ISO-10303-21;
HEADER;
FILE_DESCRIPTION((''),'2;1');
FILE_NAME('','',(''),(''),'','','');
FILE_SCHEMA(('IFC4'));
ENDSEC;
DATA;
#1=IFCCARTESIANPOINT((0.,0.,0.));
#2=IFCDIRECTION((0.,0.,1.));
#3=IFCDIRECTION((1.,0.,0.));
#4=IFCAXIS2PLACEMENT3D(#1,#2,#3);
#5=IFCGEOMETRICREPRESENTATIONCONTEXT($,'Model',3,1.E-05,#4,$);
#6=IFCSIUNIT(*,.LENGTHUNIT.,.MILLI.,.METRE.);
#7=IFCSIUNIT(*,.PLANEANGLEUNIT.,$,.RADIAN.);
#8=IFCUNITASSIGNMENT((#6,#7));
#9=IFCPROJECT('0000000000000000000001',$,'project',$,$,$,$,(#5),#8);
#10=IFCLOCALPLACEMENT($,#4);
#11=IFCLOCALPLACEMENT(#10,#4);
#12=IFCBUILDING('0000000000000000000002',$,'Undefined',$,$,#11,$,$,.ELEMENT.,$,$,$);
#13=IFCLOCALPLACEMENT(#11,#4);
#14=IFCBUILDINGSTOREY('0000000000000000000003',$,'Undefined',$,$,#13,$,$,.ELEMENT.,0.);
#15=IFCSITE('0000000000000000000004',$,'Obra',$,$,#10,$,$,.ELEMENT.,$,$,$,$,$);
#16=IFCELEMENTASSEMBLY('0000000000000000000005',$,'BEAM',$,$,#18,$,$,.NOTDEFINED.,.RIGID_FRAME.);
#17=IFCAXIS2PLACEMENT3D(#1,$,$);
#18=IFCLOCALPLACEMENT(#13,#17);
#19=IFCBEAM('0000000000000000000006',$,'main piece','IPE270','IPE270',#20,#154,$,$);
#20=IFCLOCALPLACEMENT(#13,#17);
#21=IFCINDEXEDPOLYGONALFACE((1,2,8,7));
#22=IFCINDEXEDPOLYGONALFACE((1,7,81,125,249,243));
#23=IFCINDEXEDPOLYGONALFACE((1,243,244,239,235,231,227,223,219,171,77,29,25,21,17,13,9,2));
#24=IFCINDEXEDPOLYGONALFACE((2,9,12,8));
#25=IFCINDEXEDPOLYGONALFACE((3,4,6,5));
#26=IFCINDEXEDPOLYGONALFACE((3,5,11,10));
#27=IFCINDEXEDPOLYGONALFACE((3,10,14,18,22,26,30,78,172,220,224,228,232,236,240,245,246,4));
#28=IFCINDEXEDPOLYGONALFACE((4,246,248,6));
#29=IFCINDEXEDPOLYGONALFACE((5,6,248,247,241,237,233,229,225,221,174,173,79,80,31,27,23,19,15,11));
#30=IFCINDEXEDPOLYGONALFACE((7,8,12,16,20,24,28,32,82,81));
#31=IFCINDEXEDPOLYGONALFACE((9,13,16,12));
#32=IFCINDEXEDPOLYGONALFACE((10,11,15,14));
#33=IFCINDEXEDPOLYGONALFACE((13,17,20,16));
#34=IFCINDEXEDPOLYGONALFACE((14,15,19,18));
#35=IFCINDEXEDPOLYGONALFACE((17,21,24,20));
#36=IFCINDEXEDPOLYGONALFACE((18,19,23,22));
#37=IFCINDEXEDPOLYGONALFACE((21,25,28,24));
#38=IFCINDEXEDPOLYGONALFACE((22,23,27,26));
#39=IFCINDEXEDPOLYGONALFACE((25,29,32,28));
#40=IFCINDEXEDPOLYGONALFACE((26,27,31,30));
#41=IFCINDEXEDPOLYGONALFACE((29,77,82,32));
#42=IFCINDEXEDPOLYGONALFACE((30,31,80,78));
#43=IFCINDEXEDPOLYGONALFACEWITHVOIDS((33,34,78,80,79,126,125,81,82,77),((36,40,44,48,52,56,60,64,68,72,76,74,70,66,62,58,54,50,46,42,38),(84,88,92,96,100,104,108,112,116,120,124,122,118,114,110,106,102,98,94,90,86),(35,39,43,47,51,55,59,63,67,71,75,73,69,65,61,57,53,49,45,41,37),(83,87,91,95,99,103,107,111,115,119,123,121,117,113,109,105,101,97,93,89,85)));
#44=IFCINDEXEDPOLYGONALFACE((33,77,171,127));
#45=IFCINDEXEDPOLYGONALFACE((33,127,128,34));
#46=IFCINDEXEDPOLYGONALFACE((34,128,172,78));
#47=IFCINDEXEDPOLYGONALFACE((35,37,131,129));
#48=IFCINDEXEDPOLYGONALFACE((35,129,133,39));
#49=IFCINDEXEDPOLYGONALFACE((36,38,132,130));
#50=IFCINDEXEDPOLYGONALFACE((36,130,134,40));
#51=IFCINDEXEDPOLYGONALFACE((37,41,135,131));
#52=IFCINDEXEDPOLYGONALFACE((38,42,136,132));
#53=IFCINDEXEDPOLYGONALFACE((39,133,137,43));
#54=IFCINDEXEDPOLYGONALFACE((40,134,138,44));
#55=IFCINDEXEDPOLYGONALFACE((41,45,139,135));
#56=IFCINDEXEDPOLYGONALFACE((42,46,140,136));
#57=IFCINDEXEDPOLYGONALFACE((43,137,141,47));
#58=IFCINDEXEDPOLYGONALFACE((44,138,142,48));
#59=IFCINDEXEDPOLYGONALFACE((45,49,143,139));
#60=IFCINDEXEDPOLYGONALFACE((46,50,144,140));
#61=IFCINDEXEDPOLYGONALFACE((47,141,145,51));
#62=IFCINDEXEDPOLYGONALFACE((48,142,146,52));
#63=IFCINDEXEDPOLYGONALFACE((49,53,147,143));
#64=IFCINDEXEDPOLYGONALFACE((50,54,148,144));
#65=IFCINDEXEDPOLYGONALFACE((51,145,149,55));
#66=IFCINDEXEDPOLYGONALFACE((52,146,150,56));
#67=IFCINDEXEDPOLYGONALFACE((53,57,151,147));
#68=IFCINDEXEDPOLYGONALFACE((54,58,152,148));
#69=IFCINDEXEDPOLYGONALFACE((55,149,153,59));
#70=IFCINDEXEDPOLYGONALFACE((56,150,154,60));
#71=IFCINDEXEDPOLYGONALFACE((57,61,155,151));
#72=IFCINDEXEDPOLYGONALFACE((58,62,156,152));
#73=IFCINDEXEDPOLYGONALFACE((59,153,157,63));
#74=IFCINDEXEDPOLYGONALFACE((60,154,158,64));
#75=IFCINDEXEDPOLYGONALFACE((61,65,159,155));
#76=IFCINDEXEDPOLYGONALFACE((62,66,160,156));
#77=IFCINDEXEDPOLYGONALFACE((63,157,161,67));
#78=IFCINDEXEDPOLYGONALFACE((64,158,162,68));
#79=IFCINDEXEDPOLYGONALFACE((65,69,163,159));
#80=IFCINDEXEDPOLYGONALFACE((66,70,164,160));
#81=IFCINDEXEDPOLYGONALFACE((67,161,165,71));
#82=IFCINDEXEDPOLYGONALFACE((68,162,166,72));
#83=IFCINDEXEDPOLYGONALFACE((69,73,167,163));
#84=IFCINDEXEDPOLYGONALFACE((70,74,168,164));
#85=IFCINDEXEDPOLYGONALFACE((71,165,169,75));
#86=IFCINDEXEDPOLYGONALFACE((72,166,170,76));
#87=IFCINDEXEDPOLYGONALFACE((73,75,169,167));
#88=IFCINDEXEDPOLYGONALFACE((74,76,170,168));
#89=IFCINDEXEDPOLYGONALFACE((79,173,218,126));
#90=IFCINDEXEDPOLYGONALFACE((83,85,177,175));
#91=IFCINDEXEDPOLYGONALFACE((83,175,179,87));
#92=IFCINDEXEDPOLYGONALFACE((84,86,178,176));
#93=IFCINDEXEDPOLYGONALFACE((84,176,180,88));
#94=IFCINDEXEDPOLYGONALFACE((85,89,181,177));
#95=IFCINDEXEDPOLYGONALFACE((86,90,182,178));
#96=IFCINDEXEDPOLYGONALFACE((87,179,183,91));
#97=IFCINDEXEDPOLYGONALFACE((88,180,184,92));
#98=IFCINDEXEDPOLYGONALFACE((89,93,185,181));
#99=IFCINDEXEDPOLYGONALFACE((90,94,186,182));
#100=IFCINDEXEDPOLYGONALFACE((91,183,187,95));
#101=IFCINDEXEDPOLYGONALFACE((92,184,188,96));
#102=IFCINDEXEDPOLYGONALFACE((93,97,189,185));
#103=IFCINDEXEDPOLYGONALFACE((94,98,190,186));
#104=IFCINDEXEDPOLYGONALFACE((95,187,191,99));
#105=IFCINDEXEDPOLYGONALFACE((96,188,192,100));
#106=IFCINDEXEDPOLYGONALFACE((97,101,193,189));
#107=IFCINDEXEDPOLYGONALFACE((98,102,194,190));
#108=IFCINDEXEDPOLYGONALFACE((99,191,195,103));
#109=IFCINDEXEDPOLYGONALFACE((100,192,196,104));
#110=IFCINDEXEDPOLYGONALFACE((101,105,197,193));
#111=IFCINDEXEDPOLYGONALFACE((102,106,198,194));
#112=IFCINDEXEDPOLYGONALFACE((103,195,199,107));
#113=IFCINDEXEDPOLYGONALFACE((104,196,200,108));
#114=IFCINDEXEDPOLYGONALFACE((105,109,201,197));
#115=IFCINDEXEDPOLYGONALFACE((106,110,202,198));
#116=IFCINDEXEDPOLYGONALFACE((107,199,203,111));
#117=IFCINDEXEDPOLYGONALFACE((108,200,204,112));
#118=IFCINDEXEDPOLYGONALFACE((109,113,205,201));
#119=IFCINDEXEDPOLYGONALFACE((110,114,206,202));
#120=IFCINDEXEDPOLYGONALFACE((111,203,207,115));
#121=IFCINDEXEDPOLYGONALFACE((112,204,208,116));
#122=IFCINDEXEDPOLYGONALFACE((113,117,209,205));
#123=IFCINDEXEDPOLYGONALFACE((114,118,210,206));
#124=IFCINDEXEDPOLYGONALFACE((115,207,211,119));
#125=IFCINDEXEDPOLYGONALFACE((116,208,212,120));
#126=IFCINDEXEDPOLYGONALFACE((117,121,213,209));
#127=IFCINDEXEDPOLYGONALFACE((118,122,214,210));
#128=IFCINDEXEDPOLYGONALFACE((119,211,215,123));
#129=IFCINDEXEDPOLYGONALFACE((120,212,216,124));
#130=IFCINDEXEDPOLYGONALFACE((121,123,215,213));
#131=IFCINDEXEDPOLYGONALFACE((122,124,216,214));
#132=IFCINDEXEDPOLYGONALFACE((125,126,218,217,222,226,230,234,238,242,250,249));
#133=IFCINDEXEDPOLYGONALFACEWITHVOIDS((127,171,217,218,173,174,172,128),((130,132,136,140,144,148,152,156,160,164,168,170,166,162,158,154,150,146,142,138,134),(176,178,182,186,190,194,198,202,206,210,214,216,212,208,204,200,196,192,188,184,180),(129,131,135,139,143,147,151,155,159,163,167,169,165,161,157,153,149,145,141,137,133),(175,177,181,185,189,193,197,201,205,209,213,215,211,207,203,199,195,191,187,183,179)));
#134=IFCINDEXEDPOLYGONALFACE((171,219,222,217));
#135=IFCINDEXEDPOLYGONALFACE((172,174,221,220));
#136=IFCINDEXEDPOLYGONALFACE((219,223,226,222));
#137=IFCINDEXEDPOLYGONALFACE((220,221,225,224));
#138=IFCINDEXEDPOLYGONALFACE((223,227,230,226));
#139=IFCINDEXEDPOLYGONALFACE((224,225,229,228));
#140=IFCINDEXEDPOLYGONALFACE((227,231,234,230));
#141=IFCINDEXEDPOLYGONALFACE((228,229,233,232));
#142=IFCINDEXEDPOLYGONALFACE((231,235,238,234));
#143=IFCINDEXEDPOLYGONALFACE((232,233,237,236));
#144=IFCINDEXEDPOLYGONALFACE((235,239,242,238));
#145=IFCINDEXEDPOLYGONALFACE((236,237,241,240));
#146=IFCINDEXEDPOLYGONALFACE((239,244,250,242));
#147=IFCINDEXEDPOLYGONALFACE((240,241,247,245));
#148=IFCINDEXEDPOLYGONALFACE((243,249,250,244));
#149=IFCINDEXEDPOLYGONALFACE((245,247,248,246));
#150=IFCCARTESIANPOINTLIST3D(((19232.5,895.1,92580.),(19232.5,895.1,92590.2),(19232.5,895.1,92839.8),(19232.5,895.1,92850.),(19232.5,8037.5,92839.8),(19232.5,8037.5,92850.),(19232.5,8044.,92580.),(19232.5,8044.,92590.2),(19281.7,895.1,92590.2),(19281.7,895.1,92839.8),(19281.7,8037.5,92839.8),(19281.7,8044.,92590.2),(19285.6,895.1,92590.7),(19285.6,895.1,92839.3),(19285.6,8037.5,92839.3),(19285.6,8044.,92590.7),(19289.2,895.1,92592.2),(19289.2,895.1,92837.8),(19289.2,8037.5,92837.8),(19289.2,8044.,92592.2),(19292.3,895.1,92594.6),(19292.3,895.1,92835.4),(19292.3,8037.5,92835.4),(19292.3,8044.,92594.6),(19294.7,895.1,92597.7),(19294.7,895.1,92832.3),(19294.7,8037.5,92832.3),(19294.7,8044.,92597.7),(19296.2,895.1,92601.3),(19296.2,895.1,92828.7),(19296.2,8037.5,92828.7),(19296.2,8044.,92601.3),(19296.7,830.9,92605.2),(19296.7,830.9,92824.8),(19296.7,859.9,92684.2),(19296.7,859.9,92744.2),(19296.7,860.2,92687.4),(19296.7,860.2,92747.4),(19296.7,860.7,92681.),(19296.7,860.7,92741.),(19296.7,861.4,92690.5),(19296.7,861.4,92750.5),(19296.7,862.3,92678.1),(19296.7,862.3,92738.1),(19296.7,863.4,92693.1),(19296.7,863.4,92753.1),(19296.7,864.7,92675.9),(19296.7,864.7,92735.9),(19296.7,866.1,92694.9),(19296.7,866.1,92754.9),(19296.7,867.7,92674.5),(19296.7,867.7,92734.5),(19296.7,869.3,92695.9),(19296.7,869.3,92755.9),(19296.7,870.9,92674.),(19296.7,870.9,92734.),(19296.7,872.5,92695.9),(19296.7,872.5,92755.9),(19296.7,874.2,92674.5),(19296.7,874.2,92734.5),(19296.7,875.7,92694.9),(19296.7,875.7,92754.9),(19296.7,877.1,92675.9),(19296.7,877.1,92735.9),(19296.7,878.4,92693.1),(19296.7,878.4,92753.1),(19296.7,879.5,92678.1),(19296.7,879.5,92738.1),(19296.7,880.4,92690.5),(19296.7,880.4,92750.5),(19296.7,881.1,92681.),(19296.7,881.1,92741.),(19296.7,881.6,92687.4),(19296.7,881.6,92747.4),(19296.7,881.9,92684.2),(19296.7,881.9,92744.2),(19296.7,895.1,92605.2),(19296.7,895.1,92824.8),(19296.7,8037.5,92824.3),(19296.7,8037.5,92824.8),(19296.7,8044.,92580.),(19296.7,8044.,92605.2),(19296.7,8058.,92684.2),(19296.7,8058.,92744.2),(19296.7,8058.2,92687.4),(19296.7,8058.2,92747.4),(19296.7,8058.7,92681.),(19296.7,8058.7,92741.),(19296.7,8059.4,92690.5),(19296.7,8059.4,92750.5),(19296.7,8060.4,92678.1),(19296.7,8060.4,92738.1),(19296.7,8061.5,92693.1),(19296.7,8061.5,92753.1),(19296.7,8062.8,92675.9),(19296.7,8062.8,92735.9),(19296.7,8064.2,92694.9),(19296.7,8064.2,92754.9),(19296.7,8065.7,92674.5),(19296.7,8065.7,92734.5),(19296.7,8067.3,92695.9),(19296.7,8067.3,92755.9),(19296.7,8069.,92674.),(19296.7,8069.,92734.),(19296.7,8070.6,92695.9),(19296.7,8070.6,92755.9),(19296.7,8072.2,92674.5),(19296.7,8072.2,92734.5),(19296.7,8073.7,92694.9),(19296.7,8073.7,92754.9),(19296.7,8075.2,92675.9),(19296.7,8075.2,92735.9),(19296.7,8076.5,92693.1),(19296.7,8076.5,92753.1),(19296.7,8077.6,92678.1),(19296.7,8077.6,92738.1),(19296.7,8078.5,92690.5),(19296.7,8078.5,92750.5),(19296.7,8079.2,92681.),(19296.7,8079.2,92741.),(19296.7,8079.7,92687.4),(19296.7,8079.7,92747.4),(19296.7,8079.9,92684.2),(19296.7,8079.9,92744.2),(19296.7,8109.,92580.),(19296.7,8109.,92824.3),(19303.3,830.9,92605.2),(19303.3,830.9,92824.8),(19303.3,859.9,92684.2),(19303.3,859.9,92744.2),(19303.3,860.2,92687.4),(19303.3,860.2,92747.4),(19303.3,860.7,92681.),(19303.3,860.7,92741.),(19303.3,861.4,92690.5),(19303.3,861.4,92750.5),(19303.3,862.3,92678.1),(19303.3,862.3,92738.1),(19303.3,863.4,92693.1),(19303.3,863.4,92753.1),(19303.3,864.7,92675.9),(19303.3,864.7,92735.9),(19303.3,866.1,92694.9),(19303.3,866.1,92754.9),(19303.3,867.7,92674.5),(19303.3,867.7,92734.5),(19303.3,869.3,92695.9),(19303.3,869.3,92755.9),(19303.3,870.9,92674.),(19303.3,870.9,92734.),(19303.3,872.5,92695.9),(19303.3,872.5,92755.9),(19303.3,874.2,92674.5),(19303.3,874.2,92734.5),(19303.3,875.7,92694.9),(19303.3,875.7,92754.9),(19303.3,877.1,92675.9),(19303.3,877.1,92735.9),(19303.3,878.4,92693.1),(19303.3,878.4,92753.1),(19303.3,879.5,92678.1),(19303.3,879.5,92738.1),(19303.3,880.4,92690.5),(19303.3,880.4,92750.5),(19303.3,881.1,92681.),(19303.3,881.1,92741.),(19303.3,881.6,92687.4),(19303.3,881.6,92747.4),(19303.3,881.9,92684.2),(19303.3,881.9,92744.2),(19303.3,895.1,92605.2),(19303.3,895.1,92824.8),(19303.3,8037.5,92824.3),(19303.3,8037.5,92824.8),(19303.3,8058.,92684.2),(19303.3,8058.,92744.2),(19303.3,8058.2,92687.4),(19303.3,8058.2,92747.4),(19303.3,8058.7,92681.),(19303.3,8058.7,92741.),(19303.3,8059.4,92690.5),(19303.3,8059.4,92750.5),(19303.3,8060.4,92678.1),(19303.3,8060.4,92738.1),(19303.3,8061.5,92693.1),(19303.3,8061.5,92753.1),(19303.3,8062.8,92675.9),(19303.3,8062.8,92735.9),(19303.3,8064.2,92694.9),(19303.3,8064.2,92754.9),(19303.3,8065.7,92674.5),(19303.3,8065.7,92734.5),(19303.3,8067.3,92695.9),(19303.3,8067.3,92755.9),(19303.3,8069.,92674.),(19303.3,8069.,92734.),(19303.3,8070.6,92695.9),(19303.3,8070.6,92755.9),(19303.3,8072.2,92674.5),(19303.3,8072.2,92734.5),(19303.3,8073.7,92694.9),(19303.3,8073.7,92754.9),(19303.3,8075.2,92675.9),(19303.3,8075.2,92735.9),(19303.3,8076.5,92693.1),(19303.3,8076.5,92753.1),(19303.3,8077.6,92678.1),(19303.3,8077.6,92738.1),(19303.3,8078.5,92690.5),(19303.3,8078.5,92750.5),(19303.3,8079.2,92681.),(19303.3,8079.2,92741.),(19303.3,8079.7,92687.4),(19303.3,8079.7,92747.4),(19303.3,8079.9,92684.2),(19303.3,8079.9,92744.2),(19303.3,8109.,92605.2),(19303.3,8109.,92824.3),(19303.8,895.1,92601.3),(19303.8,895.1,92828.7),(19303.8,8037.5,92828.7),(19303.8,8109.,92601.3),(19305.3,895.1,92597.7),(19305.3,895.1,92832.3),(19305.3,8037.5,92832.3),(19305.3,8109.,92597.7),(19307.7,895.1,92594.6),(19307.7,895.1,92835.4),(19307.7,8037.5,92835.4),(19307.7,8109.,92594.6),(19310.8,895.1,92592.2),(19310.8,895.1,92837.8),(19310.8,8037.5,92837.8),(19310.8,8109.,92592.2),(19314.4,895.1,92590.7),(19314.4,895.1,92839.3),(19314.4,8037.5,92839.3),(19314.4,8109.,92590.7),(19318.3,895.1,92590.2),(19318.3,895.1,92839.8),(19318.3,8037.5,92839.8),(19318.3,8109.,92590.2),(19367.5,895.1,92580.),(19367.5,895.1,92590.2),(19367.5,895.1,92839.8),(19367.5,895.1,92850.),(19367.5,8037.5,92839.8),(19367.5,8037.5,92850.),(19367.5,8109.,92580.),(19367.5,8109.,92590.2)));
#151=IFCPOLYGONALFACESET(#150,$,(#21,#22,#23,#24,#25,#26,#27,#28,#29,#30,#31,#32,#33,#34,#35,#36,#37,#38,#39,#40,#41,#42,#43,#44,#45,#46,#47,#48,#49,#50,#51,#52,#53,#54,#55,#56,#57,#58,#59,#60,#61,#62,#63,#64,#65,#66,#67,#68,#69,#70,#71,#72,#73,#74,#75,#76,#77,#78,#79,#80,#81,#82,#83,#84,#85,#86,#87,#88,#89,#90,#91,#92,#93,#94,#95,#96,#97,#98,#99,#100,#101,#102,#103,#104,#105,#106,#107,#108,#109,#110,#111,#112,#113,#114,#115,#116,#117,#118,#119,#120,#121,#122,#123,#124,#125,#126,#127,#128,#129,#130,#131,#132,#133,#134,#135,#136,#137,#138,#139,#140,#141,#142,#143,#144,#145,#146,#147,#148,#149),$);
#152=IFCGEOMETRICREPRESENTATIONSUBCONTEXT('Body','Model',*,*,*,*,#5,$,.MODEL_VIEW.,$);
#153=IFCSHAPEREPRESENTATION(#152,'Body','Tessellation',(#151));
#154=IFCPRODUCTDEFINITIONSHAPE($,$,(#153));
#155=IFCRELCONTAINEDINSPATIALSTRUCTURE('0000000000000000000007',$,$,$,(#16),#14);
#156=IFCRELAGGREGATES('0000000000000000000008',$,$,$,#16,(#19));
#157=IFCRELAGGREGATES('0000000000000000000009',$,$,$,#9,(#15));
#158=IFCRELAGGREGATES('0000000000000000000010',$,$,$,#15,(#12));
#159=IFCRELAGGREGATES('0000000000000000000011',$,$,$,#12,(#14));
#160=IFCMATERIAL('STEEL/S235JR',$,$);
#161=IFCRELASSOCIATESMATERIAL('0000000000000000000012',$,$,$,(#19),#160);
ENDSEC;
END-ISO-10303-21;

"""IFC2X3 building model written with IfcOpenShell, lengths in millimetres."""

from ifc_helpers import new_model, si_unit, frame, origin_with_axes, origin_2d_with_axis, place, context, subcontext, project, spatial, rectangle, circle, i_section, extrude, clip, halfspace, source, transform, mapped, material, element, aggregate, save


model = new_model("IFC2X3")

# Units and contexts
model_context = context("Model", 3, precision=1e-05, world=origin_with_axes())
body_context = subcontext(model_context, "Body", "Model", "MODEL_VIEW")
ifc_project = project(units=[si_unit("LENGTHUNIT", "METRE", prefix="MILLI"), si_unit("PLANEANGLEUNIT", "RADIAN")], contexts=[model_context])

# Site, building, storey
site_placement = place(None, origin_with_axes())
site = spatial("IfcSite", under=ifc_project, at=site_placement, Name="Obra", CompositionType="ELEMENT")
building_placement = place(site_placement, origin_with_axes())
building = spatial("IfcBuilding", under=site, at=building_placement, Name="Undefined", CompositionType="ELEMENT")
storey_placement = place(building_placement, origin_with_axes())
storey = spatial("IfcBuildingStorey", under=building, at=storey_placement, Name="Undefined", CompositionType="ELEMENT", Elevation=0.0)

# Shared definitions
ifc_material = material(Name="STEEL/S235JR")

# Element assembly, beam, openings
shared_shape = source(origin_with_axes(), body_context, "Body", "SweptSolid", [
    extrude(circle(Radius=11.0, at=origin_2d_with_axis()), frame((0.0, -3.4, 0.0), z_axis=(0.0, 1.0, 0.0), x_axis=(1.0, 0.0, 0.0)), (0.0, 0.0, 1.0), 6.8),
])
assembly_1_placement = place(storey_placement, origin_with_axes())
assembly_1 = element("IfcElementAssembly", 1, at=assembly_1_placement, inside=storey, Name="BEAM", AssemblyPlace="NOTDEFINED", PredefinedType="RIGID_FRAME")
beam_1_placement = place(assembly_1_placement, frame((19300.0, 905.1, 92715.0), z_axis=(0.0, 0.0, 1.0), x_axis=(0.0, 1.0, 0.0)))
beam_1 = element("IfcBeam", 2, at=beam_1_placement, material=ifc_material, Name="main piece", Description="IPE270", ObjectType="IPE270", context=body_context, shape_type="Clipping", body=[
    clip(clip(extrude(i_section(OverallWidth=135.0, OverallDepth=270.0, WebThickness=6.6, FlangeThickness=10.2, FilletRadius=15.0, at=origin_2d_with_axis()), frame((7203.9, 0.0, 0.0), z_axis=(-1.0, 0.0, 0.0), x_axis=(0.0, -1.0, 0.0)), (0.0, 0.0, 1.0), 7278.1), halfspace(frame((7203.9, 0.0, -235.0), z_axis=(-1.0, 0.0, 0.0), x_axis=(0.0, 1.0, 0.0)), True)), halfspace(frame((-74.2, 0.0, -235.0), z_axis=(1.0, 0.0, 0.0), x_axis=(0.0, -1.0, 0.0)), True)),
])
opening_1_placement = place(assembly_1_placement, frame((19300.0, 905.1, 92715.0), z_axis=(0.0, 0.0, 1.0), x_axis=(0.0, 1.0, 0.0)))
element("IfcOpeningElement", 3, at=opening_1_placement, cuts=beam_1, ObjectType="Recess", context=body_context, shape_type="SweptSolid", body=[
    extrude(rectangle(XDim=75.0, YDim=300.0, at=origin_2d_with_axis()), frame((7176.4, 153.3, 124.3), z_axis=(0.0, 0.0, -1.0), x_axis=(-1.0, 0.0, 0.0)), (0.0, 0.0, 1.0), 278.6),
])
opening_2_placement = place(assembly_1_placement, frame((19300.0, 905.1, 92715.0), z_axis=(0.0, 0.0, 1.0), x_axis=(0.0, 1.0, 0.0)))
element("IfcOpeningElement", 4, at=opening_2_placement, cuts=beam_1, ObjectType="Recess", context=body_context, shape_type="SweptSolid", body=[
    extrude(rectangle(XDim=26.7, YDim=83.5, at=origin_2d_with_axis()), frame((7174.1, 68.5, 122.7), z_axis=(0.0, -1.0, 0.0), x_axis=(0.0, 0.0, -1.0)), (0.0, 0.0, 1.0), 137.0),
])
opening_3_placement = place(assembly_1_placement, frame((19300.0, 905.1, 92715.0), z_axis=(0.0, 0.0, 1.0), x_axis=(0.0, 1.0, 0.0)))
element("IfcOpeningElement", 5, at=opening_3_placement, cuts=beam_1, ObjectType="Recess", context=body_context, shape_type="SweptSolid", body=[
    extrude(rectangle(XDim=26.2, YDim=76.2, at=origin_2d_with_axis()), frame((-48.1, -68.5, -122.9), z_axis=(0.0, 1.0, 0.0), x_axis=(0.0, 0.0, -1.0)), (0.0, 0.0, 1.0), 137.0),
])
opening_4_placement = place(assembly_1_placement, frame((19300.0, 905.1, 92715.0), z_axis=(0.0, 0.0, 1.0), x_axis=(0.0, 1.0, 0.0)))
element("IfcOpeningElement", 6, at=opening_4_placement, cuts=beam_1, ObjectType="Recess", context=body_context, shape_type="SweptSolid", body=[
    extrude(rectangle(XDim=26.2, YDim=76.2, at=origin_2d_with_axis()), frame((-48.1, -68.5, 122.9), z_axis=(0.0, 1.0, 0.0), x_axis=(0.0, 0.0, -1.0)), (0.0, 0.0, 1.0), 137.0),
])
opening_5_placement = place(assembly_1_placement, frame((19300.0, 8109.0, 92850.0), z_axis=(0.0, -1.0, 0.0), x_axis=(0.0, 0.0, -1.0)))
element("IfcOpeningElement", 7, at=opening_5_placement, cuts=beam_1, ObjectType="Opening", context=body_context, shape_type="MappedRepresentation", body=[
    mapped(shared_shape, transform((105.0, 0.0, 40.0))),
    mapped(shared_shape, transform((165.0, 0.0, 40.0))),
])
opening_6_placement = place(assembly_1_placement, frame((19300.0, 830.9, 92850.0), z_axis=(0.0, 1.0, 0.0), x_axis=(0.0, 0.0, -1.0)))
element("IfcOpeningElement", 8, at=opening_6_placement, cuts=beam_1, ObjectType="Opening", context=body_context, shape_type="MappedRepresentation", body=[
    mapped(shared_shape, transform((105.0, 0.0, 40.0))),
    mapped(shared_shape, transform((165.0, 0.0, 40.0))),
])
aggregate(assembly_1, [beam_1])

save(model, "model.ifc")
